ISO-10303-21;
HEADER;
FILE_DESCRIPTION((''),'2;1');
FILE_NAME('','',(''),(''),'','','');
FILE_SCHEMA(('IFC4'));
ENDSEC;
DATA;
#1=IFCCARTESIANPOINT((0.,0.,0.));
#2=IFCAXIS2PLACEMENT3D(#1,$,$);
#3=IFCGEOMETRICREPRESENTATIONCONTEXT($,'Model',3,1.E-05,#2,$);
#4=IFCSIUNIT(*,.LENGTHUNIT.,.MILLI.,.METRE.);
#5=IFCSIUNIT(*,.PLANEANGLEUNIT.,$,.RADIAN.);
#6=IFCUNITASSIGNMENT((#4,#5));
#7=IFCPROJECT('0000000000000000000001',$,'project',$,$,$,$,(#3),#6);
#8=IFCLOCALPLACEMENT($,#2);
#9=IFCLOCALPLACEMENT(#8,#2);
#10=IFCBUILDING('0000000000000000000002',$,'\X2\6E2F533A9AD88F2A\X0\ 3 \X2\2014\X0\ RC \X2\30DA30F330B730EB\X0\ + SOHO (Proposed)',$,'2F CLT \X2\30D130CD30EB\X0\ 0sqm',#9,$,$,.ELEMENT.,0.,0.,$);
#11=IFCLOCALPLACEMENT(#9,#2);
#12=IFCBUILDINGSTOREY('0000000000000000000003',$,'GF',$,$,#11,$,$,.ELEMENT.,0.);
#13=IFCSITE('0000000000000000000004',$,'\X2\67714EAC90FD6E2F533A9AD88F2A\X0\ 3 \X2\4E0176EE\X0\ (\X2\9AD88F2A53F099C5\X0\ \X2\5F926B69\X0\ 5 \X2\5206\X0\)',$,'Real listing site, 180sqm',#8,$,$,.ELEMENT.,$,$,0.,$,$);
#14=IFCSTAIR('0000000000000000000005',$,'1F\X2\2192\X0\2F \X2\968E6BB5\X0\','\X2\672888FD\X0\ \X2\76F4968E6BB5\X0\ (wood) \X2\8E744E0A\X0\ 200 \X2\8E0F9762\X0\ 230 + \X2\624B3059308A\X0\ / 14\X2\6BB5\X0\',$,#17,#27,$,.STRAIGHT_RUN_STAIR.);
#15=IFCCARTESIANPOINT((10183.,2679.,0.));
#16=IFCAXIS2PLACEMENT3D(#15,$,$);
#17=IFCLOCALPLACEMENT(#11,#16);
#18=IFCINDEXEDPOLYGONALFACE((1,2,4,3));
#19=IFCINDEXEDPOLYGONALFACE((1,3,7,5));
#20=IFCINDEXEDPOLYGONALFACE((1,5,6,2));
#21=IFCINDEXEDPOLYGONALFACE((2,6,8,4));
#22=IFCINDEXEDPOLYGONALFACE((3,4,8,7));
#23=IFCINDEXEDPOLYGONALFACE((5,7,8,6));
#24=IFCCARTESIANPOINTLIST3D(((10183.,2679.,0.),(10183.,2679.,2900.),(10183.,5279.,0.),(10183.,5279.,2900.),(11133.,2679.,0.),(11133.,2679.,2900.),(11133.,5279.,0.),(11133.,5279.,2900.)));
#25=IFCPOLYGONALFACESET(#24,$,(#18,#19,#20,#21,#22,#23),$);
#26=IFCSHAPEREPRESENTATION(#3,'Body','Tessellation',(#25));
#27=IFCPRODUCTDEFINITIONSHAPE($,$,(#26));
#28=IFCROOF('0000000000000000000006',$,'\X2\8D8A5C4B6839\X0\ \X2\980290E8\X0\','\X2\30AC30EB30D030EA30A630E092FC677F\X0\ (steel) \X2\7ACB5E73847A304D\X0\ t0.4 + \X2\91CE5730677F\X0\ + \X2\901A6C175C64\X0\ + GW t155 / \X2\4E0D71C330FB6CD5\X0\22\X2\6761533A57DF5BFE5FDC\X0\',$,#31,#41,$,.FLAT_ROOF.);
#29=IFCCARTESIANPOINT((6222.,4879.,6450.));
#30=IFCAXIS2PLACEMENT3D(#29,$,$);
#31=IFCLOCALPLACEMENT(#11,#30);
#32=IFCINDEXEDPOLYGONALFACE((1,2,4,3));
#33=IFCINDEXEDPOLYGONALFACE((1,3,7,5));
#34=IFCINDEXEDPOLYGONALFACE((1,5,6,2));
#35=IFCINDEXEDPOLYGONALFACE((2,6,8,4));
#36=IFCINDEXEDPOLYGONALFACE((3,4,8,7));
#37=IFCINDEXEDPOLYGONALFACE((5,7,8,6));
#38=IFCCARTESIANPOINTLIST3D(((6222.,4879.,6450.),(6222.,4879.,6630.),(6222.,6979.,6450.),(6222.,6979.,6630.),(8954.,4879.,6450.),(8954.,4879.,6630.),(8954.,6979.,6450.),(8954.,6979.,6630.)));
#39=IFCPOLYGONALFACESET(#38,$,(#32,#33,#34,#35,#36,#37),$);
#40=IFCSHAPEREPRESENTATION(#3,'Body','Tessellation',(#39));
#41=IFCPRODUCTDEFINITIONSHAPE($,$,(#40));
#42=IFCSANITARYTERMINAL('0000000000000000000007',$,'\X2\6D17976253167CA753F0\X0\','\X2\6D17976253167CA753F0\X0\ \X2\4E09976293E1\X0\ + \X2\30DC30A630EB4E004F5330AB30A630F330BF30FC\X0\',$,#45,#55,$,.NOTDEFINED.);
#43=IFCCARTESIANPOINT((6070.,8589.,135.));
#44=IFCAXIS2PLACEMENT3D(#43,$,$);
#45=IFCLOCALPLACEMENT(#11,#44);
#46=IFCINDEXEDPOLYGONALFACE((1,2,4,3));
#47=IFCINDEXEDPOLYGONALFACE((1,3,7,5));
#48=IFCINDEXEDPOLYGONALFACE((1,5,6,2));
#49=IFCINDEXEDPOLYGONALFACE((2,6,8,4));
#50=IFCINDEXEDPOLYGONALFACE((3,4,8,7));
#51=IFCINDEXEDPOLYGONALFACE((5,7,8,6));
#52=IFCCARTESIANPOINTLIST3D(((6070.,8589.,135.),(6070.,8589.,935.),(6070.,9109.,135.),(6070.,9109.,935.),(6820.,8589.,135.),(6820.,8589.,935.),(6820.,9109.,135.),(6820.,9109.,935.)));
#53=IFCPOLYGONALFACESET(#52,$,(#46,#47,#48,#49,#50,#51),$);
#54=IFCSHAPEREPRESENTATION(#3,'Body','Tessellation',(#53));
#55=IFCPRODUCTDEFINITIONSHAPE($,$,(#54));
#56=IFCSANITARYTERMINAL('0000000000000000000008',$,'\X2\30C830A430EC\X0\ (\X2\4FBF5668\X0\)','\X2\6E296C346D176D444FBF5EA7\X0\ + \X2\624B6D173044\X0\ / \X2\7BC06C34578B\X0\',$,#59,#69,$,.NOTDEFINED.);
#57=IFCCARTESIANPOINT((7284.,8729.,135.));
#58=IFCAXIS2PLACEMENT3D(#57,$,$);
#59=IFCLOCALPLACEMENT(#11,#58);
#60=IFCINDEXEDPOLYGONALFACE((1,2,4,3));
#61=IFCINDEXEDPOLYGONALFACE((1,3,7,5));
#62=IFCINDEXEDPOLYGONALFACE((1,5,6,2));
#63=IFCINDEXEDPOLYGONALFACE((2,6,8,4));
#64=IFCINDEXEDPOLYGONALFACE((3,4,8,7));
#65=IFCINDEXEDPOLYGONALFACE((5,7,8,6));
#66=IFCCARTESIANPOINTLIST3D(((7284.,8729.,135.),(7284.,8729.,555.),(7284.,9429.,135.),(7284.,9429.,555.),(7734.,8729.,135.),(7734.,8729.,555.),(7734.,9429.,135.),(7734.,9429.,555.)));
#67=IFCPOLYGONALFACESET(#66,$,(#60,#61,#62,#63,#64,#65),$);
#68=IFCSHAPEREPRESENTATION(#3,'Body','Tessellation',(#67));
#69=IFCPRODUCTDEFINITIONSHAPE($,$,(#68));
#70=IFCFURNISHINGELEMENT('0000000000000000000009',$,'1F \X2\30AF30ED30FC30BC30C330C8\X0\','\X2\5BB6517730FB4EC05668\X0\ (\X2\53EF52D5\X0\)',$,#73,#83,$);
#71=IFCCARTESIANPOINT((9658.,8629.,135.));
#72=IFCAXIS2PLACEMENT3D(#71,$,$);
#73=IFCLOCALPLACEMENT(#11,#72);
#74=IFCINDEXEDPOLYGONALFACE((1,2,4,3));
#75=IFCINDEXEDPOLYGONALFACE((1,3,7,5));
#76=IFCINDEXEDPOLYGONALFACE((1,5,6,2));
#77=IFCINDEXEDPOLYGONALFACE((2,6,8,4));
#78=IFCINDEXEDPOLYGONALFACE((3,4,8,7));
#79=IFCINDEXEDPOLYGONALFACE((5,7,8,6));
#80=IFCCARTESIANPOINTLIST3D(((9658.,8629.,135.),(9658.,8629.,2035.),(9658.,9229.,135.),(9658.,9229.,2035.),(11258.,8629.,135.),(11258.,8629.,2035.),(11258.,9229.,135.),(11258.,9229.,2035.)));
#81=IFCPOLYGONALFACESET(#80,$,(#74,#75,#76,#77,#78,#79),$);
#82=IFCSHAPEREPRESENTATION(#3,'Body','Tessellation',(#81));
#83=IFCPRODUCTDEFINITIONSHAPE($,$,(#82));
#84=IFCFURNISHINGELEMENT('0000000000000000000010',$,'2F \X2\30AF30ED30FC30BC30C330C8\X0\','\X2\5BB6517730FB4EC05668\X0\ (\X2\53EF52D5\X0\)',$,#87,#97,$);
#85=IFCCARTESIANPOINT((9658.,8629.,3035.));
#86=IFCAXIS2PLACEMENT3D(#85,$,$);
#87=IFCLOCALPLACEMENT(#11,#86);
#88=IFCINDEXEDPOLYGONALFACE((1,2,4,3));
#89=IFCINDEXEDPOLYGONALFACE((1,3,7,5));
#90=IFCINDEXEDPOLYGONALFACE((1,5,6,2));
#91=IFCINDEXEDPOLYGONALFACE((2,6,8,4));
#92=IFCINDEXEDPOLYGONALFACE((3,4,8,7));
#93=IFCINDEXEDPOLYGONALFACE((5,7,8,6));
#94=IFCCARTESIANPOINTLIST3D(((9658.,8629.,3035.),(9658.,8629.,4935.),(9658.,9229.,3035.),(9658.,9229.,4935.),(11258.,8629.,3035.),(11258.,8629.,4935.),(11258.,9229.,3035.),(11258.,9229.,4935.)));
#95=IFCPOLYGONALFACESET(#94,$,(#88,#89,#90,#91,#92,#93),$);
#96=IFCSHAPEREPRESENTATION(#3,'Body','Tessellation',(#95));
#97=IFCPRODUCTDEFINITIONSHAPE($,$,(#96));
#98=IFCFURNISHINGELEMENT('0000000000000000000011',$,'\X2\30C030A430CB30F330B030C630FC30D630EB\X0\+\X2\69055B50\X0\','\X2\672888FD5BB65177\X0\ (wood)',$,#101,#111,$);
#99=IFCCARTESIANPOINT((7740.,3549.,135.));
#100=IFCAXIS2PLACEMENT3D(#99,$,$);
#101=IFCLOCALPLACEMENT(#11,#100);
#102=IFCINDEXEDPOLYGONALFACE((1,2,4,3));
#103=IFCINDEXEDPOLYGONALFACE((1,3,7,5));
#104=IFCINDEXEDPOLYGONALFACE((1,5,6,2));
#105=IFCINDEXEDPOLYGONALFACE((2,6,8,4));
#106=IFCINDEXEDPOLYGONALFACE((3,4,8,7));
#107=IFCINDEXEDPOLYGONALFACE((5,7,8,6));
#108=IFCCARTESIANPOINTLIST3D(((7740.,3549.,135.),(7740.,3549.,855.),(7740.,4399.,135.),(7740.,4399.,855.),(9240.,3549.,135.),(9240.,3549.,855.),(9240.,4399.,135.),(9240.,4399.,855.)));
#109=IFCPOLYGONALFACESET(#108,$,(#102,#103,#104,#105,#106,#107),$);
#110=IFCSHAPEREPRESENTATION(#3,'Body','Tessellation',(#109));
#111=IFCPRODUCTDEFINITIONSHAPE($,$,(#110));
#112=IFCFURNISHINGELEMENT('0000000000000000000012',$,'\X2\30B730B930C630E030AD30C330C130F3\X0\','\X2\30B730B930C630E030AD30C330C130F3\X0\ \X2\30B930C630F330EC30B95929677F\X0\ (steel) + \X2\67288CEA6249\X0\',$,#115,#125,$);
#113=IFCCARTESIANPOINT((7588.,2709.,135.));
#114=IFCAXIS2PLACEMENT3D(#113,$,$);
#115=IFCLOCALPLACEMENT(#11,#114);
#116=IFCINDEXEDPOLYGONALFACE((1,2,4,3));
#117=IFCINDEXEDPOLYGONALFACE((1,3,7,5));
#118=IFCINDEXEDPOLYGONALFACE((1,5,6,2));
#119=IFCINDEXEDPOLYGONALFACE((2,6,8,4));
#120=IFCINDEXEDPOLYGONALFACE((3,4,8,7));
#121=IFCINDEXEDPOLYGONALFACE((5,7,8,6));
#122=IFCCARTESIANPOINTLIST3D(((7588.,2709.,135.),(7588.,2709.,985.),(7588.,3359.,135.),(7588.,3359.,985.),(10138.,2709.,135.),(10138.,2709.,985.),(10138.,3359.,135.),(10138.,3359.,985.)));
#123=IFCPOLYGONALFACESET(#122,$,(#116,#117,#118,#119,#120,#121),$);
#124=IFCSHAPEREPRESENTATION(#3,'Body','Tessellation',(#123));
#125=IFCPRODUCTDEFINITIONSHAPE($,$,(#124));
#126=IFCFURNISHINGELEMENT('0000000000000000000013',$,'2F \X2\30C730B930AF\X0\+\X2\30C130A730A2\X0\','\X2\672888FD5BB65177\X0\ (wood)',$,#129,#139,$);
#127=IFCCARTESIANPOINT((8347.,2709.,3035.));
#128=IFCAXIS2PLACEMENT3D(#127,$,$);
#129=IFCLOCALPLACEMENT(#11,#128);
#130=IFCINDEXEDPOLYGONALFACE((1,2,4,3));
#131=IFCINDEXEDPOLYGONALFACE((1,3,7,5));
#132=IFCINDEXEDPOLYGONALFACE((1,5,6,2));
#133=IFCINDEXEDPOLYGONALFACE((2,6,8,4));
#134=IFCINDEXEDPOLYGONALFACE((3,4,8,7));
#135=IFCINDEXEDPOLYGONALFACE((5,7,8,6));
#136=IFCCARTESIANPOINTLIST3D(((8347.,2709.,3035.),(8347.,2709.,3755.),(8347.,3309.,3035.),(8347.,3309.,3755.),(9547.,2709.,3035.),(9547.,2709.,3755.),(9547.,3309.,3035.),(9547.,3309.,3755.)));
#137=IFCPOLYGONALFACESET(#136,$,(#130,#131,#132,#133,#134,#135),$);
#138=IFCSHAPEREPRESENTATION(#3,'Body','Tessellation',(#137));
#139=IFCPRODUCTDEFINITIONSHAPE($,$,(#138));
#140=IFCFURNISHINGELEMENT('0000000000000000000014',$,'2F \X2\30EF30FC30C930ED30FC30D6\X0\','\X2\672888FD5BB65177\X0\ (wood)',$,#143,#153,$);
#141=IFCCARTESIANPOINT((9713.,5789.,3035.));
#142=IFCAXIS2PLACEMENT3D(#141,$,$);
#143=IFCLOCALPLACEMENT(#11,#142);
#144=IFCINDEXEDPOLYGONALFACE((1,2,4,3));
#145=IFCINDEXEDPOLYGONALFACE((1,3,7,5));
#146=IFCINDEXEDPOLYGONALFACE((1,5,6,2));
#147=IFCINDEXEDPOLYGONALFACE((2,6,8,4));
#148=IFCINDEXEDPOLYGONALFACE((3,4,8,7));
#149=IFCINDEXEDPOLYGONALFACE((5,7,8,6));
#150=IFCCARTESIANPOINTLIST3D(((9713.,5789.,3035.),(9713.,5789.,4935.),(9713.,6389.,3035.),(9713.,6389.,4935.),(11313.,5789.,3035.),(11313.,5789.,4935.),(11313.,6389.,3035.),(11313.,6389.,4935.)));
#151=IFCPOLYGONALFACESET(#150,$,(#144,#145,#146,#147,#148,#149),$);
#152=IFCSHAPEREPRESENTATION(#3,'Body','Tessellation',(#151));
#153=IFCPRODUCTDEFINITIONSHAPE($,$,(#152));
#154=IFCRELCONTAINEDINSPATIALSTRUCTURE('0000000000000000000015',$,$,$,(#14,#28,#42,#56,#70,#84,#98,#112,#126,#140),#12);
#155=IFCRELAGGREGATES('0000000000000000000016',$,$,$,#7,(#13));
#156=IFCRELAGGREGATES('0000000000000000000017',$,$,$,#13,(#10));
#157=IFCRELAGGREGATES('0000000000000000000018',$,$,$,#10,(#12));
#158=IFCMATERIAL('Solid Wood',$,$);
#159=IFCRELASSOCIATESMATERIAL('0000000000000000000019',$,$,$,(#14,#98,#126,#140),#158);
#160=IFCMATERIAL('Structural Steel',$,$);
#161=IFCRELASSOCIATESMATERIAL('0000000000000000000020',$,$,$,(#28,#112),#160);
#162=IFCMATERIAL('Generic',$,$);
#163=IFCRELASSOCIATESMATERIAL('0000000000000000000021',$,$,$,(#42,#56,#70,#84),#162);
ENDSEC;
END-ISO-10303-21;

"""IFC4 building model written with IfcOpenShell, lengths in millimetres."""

from ifc_helpers import new_model, si_unit, frame, frame_2d, origin, place, context, project, spatial, rectangle, extrude, material, element, save


model = new_model("IFC4")

# Units and contexts
model_context = context("Model", 3, precision=1e-05, world=origin())
ifc_project = project(units=[si_unit("LENGTHUNIT", "METRE", prefix="MILLI"), si_unit("PLANEANGLEUNIT", "RADIAN")], contexts=[model_context])

# Site, building, storey
site_placement = place(None, origin())
site = spatial("IfcSite", under=ifc_project, at=site_placement, Name="東京都港区高輪 3 丁目 (高輪台駅 徒歩 5 分)", ObjectType="Real listing site, 180sqm", CompositionType="ELEMENT", RefElevation=0.0)
building_placement = place(site_placement, origin())
building = spatial("IfcBuilding", under=site, at=building_placement, Name="港区高輪 3 — RC ペンシル + SOHO (Proposed)", ObjectType="2F CLT パネル 0sqm", CompositionType="ELEMENT", ElevationOfRefHeight=0.0, ElevationOfTerrain=0.0)
storey_placement = place(building_placement, origin())
storey = spatial("IfcBuildingStorey", under=building, at=storey_placement, Name="GF", CompositionType="ELEMENT", Elevation=0.0)

# Shared definitions
ifc_material_1 = material(Name="Solid Wood")

# Stair
stair_placement = place(storey_placement, frame((10183.0, 2679.0, 0.0)))
element("IfcStair", 1, at=stair_placement, inside=storey, material=ifc_material_1, Name="1F→2F 階段", Description="木製 直階段 (wood) 蹴上 200 踏面 230 + 手すり / 14段", PredefinedType="STRAIGHT_RUN_STAIR", context=model_context, shape_type="SweptSolid", body=[
    extrude(rectangle(XDim=950.0, YDim=2600.0, at=frame_2d((475.0, 1300.0))), frame((10183.0, 2679.0, 0.0)), (0.0, 0.0, 1.0), 2900.0),
])

# Roof
ifc_material_2 = material(Name="Structural Steel")
roof_placement = place(storey_placement, frame((6222.0, 4879.0, 6450.0)))
element("IfcRoof", 2, at=roof_placement, inside=storey, material=ifc_material_2, Name="越屋根 頂部", Description="ガルバリウム鋼板 (steel) 立平葺き t0.4 + 野地板 + 通気層 + GW t155 / 不燃・法22条区域対応", PredefinedType="FLAT_ROOF", context=model_context, shape_type="SweptSolid", body=[
    extrude(rectangle(XDim=2732.0, YDim=2100.0, at=frame_2d((1366.0, 1050.0))), frame((6222.0, 4879.0, 6450.0)), (0.0, 0.0, 1.0), 180.0),
])

# Sanitary terminals
ifc_material_3 = material(Name="Generic")
sanitary_terminal_1_placement = place(storey_placement, frame((6070.0, 8589.0, 135.0)))
element("IfcSanitaryTerminal", 3, at=sanitary_terminal_1_placement, inside=storey, material=ifc_material_3, Name="洗面化粧台", Description="洗面化粧台 三面鏡 + ボウル一体カウンター", PredefinedType="NOTDEFINED", context=model_context, shape_type="SweptSolid", body=[
    extrude(rectangle(XDim=750.0, YDim=520.0, at=frame_2d((375.0, 260.0))), frame((6070.0, 8589.0, 135.0)), (0.0, 0.0, 1.0), 800.0),
])
sanitary_terminal_2_placement = place(storey_placement, frame((7284.0, 8729.0, 135.0)))
element("IfcSanitaryTerminal", 4, at=sanitary_terminal_2_placement, inside=storey, material=ifc_material_3, Name="トイレ (便器)", Description="温水洗浄便座 + 手洗い / 節水型", PredefinedType="NOTDEFINED", context=model_context, shape_type="SweptSolid", body=[
    extrude(rectangle(XDim=450.0, YDim=700.0, at=frame_2d((225.0, 350.0))), frame((7284.0, 8729.0, 135.0)), (0.0, 0.0, 1.0), 420.0),
])

# Furnishing elements
furnishing_1_placement = place(storey_placement, frame((9658.0, 8629.0, 135.0)))
element("IfcFurnishingElement", 5, at=furnishing_1_placement, inside=storey, material=ifc_material_3, Name="1F クローゼット", Description="家具・什器 (可動)", context=model_context, shape_type="SweptSolid", body=[
    extrude(rectangle(XDim=1600.0, YDim=600.0, at=frame_2d((800.0, 300.0))), frame((9658.0, 8629.0, 135.0)), (0.0, 0.0, 1.0), 1900.0),
])
furnishing_2_placement = place(storey_placement, frame((9658.0, 8629.0, 3035.0)))
element("IfcFurnishingElement", 6, at=furnishing_2_placement, inside=storey, material=ifc_material_3, Name="2F クローゼット", Description="家具・什器 (可動)", context=model_context, shape_type="SweptSolid", body=[
    extrude(rectangle(XDim=1600.0, YDim=600.0, at=frame_2d((800.0, 300.0))), frame((9658.0, 8629.0, 3035.0)), (0.0, 0.0, 1.0), 1900.0),
])
furnishing_3_placement = place(storey_placement, frame((7740.0, 3549.0, 135.0)))
element("IfcFurnishingElement", 7, at=furnishing_3_placement, inside=storey, material=ifc_material_1, Name="ダイニングテーブル+椅子", Description="木製家具 (wood)", context=model_context, shape_type="SweptSolid", body=[
    extrude(rectangle(XDim=1500.0, YDim=850.0, at=frame_2d((750.0, 425.0))), frame((7740.0, 3549.0, 135.0)), (0.0, 0.0, 1.0), 720.0),
])
furnishing_4_placement = place(storey_placement, frame((7588.0, 2709.0, 135.0)))
element("IfcFurnishingElement", 8, at=furnishing_4_placement, inside=storey, material=ifc_material_2, Name="システムキッチン", Description="システムキッチン ステンレス天板 (steel) + 木質扉", context=model_context, shape_type="SweptSolid", body=[
    extrude(rectangle(XDim=2550.0, YDim=650.0, at=frame_2d((1275.0, 325.0))), frame((7588.0, 2709.0, 135.0)), (0.0, 0.0, 1.0), 850.0),
])
furnishing_5_placement = place(storey_placement, frame((8347.0, 2709.0, 3035.0)))
element("IfcFurnishingElement", 9, at=furnishing_5_placement, inside=storey, material=ifc_material_1, Name="2F デスク+チェア", Description="木製家具 (wood)", context=model_context, shape_type="SweptSolid", body=[
    extrude(rectangle(XDim=1200.0, YDim=600.0, at=frame_2d((600.0, 300.0))), frame((8347.0, 2709.0, 3035.0)), (0.0, 0.0, 1.0), 720.0),
])
furnishing_6_placement = place(storey_placement, frame((9713.0, 5789.0, 3035.0)))
element("IfcFurnishingElement", 10, at=furnishing_6_placement, inside=storey, material=ifc_material_1, Name="2F ワードローブ", Description="木製家具 (wood)", context=model_context, shape_type="SweptSolid", body=[
    extrude(rectangle(XDim=1600.0, YDim=600.0, at=frame_2d((800.0, 300.0))), frame((9713.0, 5789.0, 3035.0)), (0.0, 0.0, 1.0), 1900.0),
])

save(model, "model.ifc")
